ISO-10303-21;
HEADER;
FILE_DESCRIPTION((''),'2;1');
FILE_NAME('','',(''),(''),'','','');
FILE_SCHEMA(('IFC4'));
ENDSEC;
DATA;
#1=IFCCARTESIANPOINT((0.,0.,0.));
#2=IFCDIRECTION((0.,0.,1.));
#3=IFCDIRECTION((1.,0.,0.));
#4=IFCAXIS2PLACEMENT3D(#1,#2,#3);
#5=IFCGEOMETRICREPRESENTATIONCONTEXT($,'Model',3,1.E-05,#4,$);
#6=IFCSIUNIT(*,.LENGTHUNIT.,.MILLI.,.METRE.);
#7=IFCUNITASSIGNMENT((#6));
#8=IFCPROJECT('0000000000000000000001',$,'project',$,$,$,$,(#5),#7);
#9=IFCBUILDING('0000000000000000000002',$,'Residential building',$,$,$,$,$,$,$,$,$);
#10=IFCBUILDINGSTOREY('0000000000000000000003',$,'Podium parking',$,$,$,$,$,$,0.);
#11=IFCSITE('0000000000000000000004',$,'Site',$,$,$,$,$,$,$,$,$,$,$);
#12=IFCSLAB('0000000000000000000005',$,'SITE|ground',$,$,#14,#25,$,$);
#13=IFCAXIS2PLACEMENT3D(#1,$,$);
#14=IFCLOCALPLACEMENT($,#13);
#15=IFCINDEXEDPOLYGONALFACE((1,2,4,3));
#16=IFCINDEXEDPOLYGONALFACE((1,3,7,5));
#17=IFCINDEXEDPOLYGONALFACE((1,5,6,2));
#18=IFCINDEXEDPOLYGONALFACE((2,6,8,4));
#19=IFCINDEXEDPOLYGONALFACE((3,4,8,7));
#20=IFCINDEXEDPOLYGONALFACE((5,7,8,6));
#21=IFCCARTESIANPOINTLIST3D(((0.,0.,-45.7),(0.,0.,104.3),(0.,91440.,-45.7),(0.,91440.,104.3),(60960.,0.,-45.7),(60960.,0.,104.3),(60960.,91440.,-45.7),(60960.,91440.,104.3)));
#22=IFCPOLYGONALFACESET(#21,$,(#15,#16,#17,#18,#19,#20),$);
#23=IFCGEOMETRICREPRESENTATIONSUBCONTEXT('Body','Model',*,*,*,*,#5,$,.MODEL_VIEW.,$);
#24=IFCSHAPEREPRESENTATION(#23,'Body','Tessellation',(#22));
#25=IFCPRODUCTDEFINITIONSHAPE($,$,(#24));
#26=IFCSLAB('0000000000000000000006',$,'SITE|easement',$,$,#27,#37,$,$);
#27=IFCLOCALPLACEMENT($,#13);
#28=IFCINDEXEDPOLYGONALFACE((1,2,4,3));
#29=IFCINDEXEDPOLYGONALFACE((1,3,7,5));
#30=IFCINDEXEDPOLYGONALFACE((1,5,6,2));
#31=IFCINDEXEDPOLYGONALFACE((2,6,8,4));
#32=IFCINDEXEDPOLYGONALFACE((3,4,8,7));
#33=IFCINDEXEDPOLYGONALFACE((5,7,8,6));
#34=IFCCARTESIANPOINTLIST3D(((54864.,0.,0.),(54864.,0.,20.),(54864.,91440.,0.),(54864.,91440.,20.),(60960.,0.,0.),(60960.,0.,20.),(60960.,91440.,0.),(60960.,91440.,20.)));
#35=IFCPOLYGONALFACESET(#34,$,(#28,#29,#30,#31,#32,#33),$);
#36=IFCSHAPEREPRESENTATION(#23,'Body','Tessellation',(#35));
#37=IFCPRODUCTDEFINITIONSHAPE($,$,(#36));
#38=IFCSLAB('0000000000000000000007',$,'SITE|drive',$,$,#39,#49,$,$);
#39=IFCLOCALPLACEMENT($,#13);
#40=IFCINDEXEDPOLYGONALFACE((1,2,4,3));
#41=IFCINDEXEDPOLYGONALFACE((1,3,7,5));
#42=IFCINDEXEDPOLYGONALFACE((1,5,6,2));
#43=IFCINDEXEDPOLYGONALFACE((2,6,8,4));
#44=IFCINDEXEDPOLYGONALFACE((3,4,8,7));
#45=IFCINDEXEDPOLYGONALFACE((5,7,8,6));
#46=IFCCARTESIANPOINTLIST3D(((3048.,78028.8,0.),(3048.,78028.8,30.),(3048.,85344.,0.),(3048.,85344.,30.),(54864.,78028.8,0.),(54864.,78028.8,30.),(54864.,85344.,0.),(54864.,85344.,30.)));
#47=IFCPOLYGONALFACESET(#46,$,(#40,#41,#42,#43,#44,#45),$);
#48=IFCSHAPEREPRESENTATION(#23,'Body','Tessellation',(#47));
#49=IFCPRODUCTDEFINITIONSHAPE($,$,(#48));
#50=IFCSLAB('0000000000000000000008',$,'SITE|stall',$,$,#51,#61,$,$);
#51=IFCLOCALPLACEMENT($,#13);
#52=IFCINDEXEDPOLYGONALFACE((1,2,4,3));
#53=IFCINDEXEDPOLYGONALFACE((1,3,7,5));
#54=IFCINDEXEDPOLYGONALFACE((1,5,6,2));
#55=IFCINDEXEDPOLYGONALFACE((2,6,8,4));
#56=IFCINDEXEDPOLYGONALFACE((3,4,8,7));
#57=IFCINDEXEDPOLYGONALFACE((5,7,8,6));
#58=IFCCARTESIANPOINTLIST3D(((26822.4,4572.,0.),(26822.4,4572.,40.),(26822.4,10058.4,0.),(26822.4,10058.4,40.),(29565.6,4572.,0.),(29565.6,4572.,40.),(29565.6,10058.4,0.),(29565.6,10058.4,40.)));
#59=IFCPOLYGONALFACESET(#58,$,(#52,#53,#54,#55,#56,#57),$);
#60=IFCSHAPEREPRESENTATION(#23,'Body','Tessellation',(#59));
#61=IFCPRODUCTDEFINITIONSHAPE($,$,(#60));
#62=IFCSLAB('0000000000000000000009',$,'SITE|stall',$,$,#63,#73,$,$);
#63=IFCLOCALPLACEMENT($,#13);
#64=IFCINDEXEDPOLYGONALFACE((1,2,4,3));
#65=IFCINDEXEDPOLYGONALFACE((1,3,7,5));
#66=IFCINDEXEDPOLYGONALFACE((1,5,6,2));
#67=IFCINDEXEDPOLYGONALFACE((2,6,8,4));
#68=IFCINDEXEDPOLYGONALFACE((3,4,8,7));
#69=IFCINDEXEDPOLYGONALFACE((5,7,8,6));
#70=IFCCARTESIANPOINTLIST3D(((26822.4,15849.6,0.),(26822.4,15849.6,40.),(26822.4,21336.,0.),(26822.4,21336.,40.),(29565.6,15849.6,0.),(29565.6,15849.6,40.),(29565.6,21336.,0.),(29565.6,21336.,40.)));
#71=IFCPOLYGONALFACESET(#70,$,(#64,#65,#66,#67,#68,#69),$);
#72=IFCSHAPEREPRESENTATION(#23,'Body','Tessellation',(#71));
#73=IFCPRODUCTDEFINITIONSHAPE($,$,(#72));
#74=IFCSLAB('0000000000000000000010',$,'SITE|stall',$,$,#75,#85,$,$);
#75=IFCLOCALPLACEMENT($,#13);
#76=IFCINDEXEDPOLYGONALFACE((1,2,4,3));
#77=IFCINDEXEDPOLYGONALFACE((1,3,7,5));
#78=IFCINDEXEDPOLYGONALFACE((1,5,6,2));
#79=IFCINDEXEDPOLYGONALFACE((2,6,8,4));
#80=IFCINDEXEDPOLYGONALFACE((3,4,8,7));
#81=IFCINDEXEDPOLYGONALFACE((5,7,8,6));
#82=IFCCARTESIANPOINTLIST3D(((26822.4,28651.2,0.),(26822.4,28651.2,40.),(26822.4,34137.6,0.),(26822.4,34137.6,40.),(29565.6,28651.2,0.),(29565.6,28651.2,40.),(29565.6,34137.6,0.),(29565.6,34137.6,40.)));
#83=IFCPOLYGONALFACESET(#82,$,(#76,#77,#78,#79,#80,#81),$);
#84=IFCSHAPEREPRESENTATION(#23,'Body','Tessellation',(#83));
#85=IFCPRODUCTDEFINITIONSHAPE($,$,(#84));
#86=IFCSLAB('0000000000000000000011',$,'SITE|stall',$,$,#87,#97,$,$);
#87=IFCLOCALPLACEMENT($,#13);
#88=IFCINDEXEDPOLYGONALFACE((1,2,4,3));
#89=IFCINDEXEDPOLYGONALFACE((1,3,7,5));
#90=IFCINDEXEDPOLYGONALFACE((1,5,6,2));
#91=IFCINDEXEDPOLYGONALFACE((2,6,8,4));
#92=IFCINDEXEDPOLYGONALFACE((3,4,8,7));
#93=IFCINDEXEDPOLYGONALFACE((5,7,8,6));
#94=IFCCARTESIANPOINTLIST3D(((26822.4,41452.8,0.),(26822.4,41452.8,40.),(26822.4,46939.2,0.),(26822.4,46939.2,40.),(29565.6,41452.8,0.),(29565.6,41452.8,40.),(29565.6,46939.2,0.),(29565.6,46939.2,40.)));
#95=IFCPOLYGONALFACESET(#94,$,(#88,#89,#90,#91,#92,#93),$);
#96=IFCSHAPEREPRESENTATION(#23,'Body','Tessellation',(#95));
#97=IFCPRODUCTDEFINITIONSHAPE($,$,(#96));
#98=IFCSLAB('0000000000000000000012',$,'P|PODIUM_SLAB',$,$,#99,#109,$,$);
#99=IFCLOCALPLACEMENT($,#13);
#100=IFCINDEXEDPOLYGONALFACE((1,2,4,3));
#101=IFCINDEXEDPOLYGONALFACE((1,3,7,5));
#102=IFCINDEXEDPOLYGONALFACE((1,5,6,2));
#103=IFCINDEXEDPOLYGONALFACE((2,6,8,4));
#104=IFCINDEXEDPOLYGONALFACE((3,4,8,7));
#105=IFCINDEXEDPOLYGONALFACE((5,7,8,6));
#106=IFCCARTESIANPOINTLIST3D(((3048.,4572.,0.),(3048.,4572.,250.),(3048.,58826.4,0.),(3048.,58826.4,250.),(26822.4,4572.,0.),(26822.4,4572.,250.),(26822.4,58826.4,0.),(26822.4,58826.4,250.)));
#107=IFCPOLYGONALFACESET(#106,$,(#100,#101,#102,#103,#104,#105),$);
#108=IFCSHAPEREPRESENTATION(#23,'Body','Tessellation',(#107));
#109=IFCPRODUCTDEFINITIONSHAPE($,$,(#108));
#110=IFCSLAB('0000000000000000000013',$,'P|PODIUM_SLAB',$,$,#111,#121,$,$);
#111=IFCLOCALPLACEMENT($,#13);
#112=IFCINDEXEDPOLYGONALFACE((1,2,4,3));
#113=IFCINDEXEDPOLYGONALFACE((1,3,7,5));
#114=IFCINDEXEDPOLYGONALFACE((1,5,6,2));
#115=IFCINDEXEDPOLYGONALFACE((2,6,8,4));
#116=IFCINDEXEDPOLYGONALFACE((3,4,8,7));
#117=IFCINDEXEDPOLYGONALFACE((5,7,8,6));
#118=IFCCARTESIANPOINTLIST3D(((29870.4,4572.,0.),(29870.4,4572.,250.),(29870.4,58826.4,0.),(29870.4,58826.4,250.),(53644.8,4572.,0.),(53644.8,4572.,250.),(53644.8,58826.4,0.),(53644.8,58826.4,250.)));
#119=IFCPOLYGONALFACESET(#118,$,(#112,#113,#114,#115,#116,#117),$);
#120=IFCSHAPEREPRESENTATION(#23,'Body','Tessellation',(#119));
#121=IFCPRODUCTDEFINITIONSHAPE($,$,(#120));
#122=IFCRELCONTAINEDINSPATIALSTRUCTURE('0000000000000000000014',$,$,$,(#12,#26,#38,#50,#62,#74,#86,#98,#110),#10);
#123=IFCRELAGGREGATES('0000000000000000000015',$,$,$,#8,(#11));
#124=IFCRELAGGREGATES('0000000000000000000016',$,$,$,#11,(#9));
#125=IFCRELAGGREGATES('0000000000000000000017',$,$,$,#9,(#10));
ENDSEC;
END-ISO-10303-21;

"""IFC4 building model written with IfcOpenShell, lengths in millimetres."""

from ifc_helpers import new_model, si_unit, frame, origin_with_axes, place, context, subcontext, project, spatial, indexed_curve, outline, extrude, element, save


model = new_model("IFC4")

# Units and contexts
model_context = context("Model", 3, precision=1e-05, world=origin_with_axes())
body_context = subcontext(model_context, "Body", "Model", "MODEL_VIEW")
ifc_project = project(units=[si_unit("LENGTHUNIT", "METRE", prefix="MILLI")], contexts=[model_context])

# Site, building, storey
site = spatial("IfcSite", under=ifc_project, Name="Site")
building = spatial("IfcBuilding", under=site, Name="Residential building")
storey = spatial("IfcBuildingStorey", under=building, Name="Podium parking", Elevation=0.0)

# Slabs
slab_1_placement = place(None, frame((0.0, 0.0, -45.7), z_axis=(0.0, 0.0, 1.0), x_axis=(1.0, 0.0, 0.0)))
element("IfcSlab", 1, at=slab_1_placement, inside=storey, Name="SITE|ground", context=body_context, shape_type="SweptSolid", body=[
    extrude(outline(indexed_curve([(0.0, 0.0), (60960.0, 0.0), (60960.0, 91440.0), (0.0, 91440.0), (0.0, 0.0)])), None, (0.0, 0.0, 1.0), 150.0),
])
slab_2_placement = place(None, frame((54864.0, 0.0, 0.0), z_axis=(0.0, 0.0, 1.0), x_axis=(1.0, 0.0, 0.0)))
element("IfcSlab", 2, at=slab_2_placement, inside=storey, Name="SITE|easement", context=body_context, shape_type="SweptSolid", body=[
    extrude(outline(indexed_curve([(0.0, 0.0), (6096.0, 0.0), (6096.0, 91440.0), (0.0, 91440.0), (0.0, 0.0)])), None, (0.0, 0.0, 1.0), 20.0),
])
slab_3_placement = place(None, frame((3048.0, 78028.8, 0.0), z_axis=(0.0, 0.0, 1.0), x_axis=(1.0, 0.0, 0.0)))
element("IfcSlab", 3, at=slab_3_placement, inside=storey, Name="SITE|drive", context=body_context, shape_type="SweptSolid", body=[
    extrude(outline(indexed_curve([(0.0, 0.0), (51816.0, 0.0), (51816.0, 7315.2), (0.0, 7315.2), (0.0, 0.0)])), None, (0.0, 0.0, 1.0), 30.0),
])
for number, where, z_axis, x_axis, name in (
    (4, (26822.4, 4572.0, 0.0), (0.0, 0.0, 1.0), (1.0, 0.0, 0.0), "SITE|stall"),
    (5, (26822.4, 15849.6, 0.0), (0.0, 0.0, 1.0), (1.0, 0.0, 0.0), "SITE|stall"),
    (6, (26822.4, 28651.2, 0.0), (0.0, 0.0, 1.0), (1.0, 0.0, 0.0), "SITE|stall"),
    (7, (26822.4, 41452.8, 0.0), (0.0, 0.0, 1.0), (1.0, 0.0, 0.0), "SITE|stall"),
):
    element("IfcSlab", number, at=place(None, frame(where, z_axis=z_axis, x_axis=x_axis)), inside=storey, Name=name, context=body_context, shape_type="SweptSolid", body=[
        extrude(outline(indexed_curve([(0.0, 0.0), (2743.2, 0.0), (2743.2, 5486.4), (0.0, 5486.4), (0.0, 0.0)])), None, (0.0, 0.0, 1.0), 40.0),
    ])
for number, where, z_axis, x_axis, name in (
    (8, (3048.0, 4572.0, 0.0), (0.0, 0.0, 1.0), (1.0, 0.0, 0.0), "P|PODIUM_SLAB"),
    (9, (29870.4, 4572.0, 0.0), (0.0, 0.0, 1.0), (1.0, 0.0, 0.0), "P|PODIUM_SLAB"),
):
    element("IfcSlab", number, at=place(None, frame(where, z_axis=z_axis, x_axis=x_axis)), inside=storey, Name=name, context=body_context, shape_type="SweptSolid", body=[
        extrude(outline(indexed_curve([(0.0, 0.0), (23774.4, 0.0), (23774.4, 54254.4), (0.0, 54254.4), (0.0, 0.0)])), None, (0.0, 0.0, 1.0), 250.0),
    ])

save(model, "model.ifc")
